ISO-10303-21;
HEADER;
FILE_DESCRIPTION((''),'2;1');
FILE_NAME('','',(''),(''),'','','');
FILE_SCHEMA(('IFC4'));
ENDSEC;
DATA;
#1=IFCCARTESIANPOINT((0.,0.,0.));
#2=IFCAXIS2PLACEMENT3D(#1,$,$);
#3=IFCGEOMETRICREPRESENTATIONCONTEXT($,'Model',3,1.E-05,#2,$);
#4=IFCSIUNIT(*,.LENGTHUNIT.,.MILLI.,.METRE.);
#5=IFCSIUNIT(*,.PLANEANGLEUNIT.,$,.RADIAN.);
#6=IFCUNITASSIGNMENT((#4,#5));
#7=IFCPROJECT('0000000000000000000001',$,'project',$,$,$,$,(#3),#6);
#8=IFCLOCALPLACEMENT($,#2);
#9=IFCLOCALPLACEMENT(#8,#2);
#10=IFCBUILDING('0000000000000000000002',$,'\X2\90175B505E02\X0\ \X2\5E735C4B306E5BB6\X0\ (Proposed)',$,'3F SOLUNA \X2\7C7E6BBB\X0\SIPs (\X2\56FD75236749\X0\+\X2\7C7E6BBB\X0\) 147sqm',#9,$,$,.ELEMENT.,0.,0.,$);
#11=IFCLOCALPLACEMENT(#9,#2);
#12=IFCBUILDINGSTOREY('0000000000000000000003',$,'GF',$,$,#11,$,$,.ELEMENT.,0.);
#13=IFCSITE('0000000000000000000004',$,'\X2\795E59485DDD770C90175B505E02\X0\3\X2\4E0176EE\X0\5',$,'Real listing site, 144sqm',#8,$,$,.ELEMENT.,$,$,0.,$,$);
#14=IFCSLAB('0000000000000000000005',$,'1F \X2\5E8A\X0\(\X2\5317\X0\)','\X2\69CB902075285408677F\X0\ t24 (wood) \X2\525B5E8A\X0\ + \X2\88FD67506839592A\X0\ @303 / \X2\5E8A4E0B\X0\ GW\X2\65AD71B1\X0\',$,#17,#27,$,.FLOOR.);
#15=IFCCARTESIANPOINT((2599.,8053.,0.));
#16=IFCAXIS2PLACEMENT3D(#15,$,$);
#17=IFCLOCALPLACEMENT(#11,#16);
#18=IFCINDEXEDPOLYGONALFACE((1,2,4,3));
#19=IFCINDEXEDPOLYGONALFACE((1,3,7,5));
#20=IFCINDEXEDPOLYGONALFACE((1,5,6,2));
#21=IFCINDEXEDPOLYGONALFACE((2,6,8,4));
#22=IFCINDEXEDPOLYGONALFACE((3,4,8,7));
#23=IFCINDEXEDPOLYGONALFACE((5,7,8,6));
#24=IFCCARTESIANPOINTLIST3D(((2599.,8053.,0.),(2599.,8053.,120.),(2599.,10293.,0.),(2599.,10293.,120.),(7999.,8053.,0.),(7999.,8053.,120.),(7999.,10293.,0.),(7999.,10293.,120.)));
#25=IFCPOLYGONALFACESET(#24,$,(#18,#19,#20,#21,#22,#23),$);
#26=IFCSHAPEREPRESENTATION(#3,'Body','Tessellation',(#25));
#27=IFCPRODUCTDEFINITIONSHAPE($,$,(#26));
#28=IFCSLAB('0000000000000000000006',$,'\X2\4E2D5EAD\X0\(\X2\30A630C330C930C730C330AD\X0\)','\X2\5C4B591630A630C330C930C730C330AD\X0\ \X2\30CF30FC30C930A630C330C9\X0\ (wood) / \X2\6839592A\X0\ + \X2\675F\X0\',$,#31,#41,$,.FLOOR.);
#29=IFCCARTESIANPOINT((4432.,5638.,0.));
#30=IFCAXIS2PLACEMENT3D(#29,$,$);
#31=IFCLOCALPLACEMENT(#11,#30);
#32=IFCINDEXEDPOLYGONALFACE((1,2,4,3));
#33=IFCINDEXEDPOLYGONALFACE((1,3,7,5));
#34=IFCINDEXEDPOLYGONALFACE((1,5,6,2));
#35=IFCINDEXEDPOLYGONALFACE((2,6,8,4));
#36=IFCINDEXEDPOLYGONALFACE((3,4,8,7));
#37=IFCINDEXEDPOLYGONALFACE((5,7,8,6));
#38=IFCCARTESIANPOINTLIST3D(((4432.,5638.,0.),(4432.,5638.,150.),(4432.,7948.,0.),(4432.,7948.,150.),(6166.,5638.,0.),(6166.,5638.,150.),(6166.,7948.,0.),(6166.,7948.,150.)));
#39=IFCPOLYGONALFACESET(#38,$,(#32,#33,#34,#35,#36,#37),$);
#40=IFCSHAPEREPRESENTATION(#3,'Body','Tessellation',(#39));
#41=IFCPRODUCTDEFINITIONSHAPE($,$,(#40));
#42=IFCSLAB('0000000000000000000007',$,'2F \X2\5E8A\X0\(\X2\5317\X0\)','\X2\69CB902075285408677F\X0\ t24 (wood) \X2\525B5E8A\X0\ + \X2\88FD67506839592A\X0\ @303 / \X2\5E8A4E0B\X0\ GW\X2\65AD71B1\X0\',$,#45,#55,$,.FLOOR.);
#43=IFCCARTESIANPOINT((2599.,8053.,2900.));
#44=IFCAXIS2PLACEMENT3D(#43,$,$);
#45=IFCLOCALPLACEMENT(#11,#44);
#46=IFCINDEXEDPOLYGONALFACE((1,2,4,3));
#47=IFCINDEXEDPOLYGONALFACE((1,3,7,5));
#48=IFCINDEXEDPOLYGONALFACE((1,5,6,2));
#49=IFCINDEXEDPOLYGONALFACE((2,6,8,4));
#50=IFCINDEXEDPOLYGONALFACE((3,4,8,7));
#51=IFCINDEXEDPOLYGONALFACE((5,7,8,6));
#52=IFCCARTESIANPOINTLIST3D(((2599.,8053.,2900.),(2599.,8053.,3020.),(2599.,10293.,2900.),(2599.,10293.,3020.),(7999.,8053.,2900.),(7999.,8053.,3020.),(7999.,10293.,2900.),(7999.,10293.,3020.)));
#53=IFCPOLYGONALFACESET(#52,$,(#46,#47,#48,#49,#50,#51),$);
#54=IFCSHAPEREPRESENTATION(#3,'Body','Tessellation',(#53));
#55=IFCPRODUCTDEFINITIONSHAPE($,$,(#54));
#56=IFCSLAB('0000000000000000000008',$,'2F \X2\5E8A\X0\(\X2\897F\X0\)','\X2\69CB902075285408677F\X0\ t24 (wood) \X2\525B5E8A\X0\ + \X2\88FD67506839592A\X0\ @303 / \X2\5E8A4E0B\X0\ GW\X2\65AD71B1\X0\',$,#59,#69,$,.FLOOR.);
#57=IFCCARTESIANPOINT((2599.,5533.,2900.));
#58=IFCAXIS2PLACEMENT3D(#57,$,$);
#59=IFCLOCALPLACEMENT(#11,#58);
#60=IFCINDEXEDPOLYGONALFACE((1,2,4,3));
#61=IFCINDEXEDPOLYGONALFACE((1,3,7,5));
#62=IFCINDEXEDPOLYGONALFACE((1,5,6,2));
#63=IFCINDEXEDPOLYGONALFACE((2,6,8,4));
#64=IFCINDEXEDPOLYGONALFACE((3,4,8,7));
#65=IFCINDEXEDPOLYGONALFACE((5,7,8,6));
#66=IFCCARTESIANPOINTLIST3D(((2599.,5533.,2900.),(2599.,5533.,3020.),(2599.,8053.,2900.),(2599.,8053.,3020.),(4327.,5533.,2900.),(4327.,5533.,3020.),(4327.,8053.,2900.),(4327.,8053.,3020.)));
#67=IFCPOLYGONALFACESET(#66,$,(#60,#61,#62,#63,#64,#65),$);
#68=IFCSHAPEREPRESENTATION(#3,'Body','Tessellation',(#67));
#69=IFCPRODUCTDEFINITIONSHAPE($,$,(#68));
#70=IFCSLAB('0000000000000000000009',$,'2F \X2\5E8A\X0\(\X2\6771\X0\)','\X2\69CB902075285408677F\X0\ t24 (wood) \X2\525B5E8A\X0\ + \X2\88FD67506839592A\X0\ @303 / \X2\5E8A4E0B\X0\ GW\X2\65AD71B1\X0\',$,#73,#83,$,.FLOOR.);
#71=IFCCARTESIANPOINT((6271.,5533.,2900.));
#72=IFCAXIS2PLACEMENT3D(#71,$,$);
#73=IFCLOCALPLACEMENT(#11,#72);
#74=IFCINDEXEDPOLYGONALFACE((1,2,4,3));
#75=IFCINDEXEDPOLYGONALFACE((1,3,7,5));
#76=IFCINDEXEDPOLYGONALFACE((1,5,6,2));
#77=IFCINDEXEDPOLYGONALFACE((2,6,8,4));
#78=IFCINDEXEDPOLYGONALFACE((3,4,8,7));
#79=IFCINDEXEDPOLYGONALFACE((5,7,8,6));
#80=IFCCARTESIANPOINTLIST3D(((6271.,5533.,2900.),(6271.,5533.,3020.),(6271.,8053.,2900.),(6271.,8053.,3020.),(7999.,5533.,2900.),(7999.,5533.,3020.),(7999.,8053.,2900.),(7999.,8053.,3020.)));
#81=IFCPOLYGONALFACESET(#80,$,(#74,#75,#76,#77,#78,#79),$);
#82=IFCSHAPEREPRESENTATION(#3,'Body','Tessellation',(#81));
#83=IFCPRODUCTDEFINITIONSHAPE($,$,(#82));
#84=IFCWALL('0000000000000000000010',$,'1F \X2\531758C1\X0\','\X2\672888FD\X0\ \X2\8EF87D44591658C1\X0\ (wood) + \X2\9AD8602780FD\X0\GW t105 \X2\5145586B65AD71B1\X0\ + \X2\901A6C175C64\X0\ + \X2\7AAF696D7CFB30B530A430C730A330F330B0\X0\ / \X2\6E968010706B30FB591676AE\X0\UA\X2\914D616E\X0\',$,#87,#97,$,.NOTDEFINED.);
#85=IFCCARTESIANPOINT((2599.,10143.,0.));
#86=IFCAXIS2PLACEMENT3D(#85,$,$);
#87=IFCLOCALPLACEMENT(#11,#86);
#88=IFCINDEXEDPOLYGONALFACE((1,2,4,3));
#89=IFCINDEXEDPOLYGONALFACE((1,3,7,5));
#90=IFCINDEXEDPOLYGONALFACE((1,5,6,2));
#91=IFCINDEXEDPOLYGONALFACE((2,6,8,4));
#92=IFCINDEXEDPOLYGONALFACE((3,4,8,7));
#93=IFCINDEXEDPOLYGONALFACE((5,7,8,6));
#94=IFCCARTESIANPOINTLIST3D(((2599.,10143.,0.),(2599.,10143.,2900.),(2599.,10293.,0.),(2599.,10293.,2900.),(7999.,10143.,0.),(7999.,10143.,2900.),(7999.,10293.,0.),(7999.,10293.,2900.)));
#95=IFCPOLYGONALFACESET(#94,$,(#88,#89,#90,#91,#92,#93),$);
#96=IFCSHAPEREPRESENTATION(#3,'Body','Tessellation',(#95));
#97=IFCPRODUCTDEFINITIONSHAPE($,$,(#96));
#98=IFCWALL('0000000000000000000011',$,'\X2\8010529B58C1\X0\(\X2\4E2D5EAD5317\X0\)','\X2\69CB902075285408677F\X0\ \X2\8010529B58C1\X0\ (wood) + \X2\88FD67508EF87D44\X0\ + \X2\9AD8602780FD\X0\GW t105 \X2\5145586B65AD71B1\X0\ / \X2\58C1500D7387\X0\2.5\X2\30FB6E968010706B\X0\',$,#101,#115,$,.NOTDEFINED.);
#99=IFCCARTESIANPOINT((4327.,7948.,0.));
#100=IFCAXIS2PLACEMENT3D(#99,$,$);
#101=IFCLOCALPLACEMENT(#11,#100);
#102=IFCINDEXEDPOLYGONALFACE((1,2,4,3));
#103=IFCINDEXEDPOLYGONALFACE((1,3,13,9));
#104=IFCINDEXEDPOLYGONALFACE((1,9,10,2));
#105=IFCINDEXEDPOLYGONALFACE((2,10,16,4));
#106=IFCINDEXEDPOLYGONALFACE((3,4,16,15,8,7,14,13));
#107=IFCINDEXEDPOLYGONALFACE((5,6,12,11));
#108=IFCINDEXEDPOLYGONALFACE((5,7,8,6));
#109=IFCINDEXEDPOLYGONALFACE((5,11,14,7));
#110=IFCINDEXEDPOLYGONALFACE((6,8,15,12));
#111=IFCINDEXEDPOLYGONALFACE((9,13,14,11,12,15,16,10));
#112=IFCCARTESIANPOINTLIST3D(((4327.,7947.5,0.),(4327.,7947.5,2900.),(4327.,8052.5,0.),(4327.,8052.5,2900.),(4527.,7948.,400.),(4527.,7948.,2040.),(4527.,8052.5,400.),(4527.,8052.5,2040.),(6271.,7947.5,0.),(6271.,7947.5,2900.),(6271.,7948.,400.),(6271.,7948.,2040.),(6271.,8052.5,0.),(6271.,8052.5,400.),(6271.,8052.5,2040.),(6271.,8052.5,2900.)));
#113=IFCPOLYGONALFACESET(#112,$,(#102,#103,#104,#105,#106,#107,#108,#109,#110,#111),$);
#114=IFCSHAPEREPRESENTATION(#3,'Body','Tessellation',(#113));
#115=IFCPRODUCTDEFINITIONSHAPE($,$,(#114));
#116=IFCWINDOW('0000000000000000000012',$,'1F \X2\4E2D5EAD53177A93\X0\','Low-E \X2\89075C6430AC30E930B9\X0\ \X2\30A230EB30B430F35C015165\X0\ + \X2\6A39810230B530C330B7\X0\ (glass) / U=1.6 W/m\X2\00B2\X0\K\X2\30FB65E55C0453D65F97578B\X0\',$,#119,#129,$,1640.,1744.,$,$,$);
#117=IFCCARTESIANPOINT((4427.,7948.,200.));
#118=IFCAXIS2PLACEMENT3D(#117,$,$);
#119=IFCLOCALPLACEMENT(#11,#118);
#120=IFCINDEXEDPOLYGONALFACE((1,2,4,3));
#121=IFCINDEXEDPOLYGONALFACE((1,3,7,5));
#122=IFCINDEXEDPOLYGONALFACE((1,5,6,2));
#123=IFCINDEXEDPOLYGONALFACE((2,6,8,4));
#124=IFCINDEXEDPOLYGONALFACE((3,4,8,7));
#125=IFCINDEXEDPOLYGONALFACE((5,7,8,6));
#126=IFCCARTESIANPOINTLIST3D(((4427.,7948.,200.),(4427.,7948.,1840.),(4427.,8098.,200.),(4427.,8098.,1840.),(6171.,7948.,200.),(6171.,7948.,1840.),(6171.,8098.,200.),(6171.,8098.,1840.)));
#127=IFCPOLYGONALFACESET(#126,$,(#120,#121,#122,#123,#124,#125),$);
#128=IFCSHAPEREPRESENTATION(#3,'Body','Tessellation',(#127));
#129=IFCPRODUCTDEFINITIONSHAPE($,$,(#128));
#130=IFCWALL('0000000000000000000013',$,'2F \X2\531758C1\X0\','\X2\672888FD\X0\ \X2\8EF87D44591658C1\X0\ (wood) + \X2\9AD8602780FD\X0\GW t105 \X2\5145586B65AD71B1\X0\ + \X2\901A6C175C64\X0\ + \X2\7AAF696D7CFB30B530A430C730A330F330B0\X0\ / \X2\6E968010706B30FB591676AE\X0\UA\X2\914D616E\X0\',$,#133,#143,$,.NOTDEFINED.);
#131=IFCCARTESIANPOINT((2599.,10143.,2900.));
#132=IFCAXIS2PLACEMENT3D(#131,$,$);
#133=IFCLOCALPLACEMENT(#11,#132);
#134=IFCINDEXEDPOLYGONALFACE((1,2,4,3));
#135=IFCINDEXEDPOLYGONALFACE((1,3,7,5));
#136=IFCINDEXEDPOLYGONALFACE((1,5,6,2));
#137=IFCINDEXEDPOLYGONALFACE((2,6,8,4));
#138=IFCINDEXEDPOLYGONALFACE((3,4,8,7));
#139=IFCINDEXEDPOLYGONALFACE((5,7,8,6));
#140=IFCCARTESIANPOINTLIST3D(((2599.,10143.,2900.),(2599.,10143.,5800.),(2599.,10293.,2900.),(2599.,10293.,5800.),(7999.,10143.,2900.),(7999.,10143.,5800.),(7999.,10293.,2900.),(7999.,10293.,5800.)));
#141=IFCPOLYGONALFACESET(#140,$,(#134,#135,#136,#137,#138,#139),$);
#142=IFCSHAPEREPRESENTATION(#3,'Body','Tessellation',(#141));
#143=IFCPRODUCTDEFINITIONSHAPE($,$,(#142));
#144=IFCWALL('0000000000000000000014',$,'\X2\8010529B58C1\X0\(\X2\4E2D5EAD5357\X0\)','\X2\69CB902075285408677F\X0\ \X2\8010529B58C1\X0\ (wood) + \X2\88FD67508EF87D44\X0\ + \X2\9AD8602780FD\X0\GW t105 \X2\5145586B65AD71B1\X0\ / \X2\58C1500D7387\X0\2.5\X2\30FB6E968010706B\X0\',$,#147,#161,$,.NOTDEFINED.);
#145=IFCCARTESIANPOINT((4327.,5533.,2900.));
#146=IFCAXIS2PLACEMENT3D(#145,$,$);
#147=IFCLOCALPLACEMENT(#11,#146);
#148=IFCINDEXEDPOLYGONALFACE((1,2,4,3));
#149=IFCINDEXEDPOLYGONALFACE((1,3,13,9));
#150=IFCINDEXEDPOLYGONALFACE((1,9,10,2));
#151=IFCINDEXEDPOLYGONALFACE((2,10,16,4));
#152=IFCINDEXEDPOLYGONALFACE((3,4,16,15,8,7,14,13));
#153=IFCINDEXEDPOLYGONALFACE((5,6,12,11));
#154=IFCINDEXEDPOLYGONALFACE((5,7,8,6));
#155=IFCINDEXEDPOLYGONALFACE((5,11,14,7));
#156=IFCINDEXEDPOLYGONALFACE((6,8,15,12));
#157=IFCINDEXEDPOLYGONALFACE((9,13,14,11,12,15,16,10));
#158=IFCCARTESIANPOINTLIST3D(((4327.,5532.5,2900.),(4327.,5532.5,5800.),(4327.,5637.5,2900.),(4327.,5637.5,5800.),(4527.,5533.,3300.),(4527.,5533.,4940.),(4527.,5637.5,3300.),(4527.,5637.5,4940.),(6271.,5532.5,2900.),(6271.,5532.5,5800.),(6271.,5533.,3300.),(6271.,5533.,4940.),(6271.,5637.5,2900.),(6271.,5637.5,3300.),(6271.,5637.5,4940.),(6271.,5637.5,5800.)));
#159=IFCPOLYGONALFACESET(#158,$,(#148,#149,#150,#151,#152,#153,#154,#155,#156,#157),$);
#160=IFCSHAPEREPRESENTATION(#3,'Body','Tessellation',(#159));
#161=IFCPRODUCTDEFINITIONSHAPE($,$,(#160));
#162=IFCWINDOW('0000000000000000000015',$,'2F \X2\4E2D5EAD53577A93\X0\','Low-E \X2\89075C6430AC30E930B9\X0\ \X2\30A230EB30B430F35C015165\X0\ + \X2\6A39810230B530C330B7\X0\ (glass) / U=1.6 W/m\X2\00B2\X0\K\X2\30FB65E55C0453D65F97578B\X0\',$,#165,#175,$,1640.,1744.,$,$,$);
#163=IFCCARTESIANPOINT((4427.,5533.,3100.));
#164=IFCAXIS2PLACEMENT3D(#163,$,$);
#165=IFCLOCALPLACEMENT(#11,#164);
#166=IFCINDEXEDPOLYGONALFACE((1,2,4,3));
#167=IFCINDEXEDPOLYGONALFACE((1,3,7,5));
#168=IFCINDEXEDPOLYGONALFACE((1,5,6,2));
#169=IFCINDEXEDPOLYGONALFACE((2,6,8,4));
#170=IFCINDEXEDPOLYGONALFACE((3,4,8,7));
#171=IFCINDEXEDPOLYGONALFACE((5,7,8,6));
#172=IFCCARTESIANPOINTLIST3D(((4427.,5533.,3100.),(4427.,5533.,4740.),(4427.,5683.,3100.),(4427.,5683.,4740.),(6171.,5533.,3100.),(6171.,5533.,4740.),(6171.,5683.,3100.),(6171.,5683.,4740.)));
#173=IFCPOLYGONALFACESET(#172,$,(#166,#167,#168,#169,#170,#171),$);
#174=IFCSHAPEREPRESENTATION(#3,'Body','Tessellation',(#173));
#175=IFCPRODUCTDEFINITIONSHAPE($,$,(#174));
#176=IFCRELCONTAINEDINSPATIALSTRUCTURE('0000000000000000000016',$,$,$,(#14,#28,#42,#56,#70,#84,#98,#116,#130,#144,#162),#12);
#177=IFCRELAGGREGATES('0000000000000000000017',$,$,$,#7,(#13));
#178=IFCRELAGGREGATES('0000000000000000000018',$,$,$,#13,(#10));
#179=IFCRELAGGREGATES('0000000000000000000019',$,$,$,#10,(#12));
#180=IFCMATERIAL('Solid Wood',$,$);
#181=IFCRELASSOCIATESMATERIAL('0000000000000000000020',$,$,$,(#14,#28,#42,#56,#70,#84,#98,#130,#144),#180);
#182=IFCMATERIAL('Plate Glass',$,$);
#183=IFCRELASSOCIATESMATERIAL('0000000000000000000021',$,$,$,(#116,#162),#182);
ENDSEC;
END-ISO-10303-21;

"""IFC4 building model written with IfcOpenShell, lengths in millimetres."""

from ifc_helpers import new_model, si_unit, frame, frame_2d, origin, place, context, project, spatial, rectangle, extrude, material, element, fill, save


model = new_model("IFC4")

# Units and contexts
model_context = context("Model", 3, precision=1e-05, world=origin())
ifc_project = project(units=[si_unit("LENGTHUNIT", "METRE", prefix="MILLI"), si_unit("PLANEANGLEUNIT", "RADIAN")], contexts=[model_context])

# Site, building, storey
site_placement = place(None, origin())
site = spatial("IfcSite", under=ifc_project, at=site_placement, Name="神奈川県逗子市3丁目5", ObjectType="Real listing site, 144sqm", CompositionType="ELEMENT", RefElevation=0.0)
building_placement = place(site_placement, origin())
building = spatial("IfcBuilding", under=site, at=building_placement, Name="逗子市 平屋の家 (Proposed)", ObjectType="3F SOLUNA 籾殻SIPs (国産杉+籾殻) 147sqm", CompositionType="ELEMENT", ElevationOfRefHeight=0.0, ElevationOfTerrain=0.0)
storey_placement = place(building_placement, origin())
storey = spatial("IfcBuildingStorey", under=building, at=storey_placement, Name="GF", CompositionType="ELEMENT", Elevation=0.0)

# Slabs
ifc_material_1 = material(Name="Solid Wood")
slab_1_placement = place(storey_placement, frame((2599.0, 8053.0, 0.0)))
element("IfcSlab", 1, at=slab_1_placement, inside=storey, material=ifc_material_1, Name="1F 床(北)", Description="構造用合板 t24 (wood) 剛床 + 製材根太 @303 / 床下 GW断熱", PredefinedType="FLOOR", context=model_context, shape_type="SweptSolid", body=[
    extrude(rectangle(XDim=5400.0, YDim=2240.0, at=frame_2d((2700.0, 1120.0))), frame((2599.0, 8053.0, 0.0)), (0.0, 0.0, 1.0), 120.0),
])
slab_2_placement = place(storey_placement, frame((4432.0, 5638.0, 0.0)))
element("IfcSlab", 2, at=slab_2_placement, inside=storey, material=ifc_material_1, Name="中庭(ウッドデッキ)", Description="屋外ウッドデッキ ハードウッド (wood) / 根太 + 束", PredefinedType="FLOOR", context=model_context, shape_type="SweptSolid", body=[
    extrude(rectangle(XDim=1734.0, YDim=2310.0, at=frame_2d((867.0, 1155.0))), frame((4432.0, 5638.0, 0.0)), (0.0, 0.0, 1.0), 150.0),
])
slab_3_placement = place(storey_placement, frame((2599.0, 8053.0, 2900.0)))
element("IfcSlab", 3, at=slab_3_placement, inside=storey, material=ifc_material_1, Name="2F 床(北)", Description="構造用合板 t24 (wood) 剛床 + 製材根太 @303 / 床下 GW断熱", PredefinedType="FLOOR", context=model_context, shape_type="SweptSolid", body=[
    extrude(rectangle(XDim=5400.0, YDim=2240.0, at=frame_2d((2700.0, 1120.0))), frame((2599.0, 8053.0, 2900.0)), (0.0, 0.0, 1.0), 120.0),
])
slab_4_placement = place(storey_placement, frame((2599.0, 5533.0, 2900.0)))
element("IfcSlab", 4, at=slab_4_placement, inside=storey, material=ifc_material_1, Name="2F 床(西)", Description="構造用合板 t24 (wood) 剛床 + 製材根太 @303 / 床下 GW断熱", PredefinedType="FLOOR", context=model_context, shape_type="SweptSolid", body=[
    extrude(rectangle(XDim=1728.0, YDim=2520.0, at=frame_2d((864.0, 1260.0))), frame((2599.0, 5533.0, 2900.0)), (0.0, 0.0, 1.0), 120.0),
])
slab_5_placement = place(storey_placement, frame((6271.0, 5533.0, 2900.0)))
element("IfcSlab", 5, at=slab_5_placement, inside=storey, material=ifc_material_1, Name="2F 床(東)", Description="構造用合板 t24 (wood) 剛床 + 製材根太 @303 / 床下 GW断熱", PredefinedType="FLOOR", context=model_context, shape_type="SweptSolid", body=[
    extrude(rectangle(XDim=1728.0, YDim=2520.0, at=frame_2d((864.0, 1260.0))), frame((6271.0, 5533.0, 2900.0)), (0.0, 0.0, 1.0), 120.0),
])

# Wall
wall_1_placement = place(storey_placement, frame((2599.0, 10143.0, 0.0)))
element("IfcWall", 6, at=wall_1_placement, inside=storey, material=ifc_material_1, Name="1F 北壁", Description="木製 軸組外壁 (wood) + 高性能GW t105 充填断熱 + 通気層 + 窯業系サイディング / 準耐火・外皮UA配慮", PredefinedType="NOTDEFINED", context=model_context, shape_type="SweptSolid", body=[
    extrude(rectangle(XDim=5400.0, YDim=150.0, at=frame_2d((2700.0, 75.0))), frame((2599.0, 10143.0, 0.0)), (0.0, 0.0, 1.0), 2900.0),
])

# Wall, opening, window
wall_2_placement = place(storey_placement, frame((4327.0, 7948.0, 0.0)))
wall_2 = element("IfcWall", 7, at=wall_2_placement, inside=storey, material=ifc_material_1, Name="耐力壁(中庭北)", Description="構造用合板 耐力壁 (wood) + 製材軸組 + 高性能GW t105 充填断熱 / 壁倍率2.5・準耐火", PredefinedType="NOTDEFINED", context=model_context, shape_type="SweptSolid", body=[
    extrude(rectangle(XDim=1944.0, YDim=105.0, at=frame_2d((972.0, 52.0))), frame((4327.0, 7948.0, 0.0)), (0.0, 0.0, 1.0), 2900.0),
])
opening_1_placement = place(storey_placement, frame((4427.0, 7948.0, 200.0)))
opening_1 = element("IfcOpeningElement", 8, at=opening_1_placement, cuts=wall_2, PredefinedType="NOTDEFINED", context=model_context, shape_type="SweptSolid", body=[
    extrude(rectangle(XDim=1744.0, YDim=150.0, at=frame_2d((872.0, 75.0))), frame((4427.0, 7948.0, 200.0)), (0.0, 0.0, 1.0), 1640.0),
])
ifc_material_2 = material(Name="Plate Glass")
window_1_placement = place(storey_placement, frame((4427.0, 7948.0, 200.0)))
window_1 = element("IfcWindow", 9, at=window_1_placement, inside=storey, material=ifc_material_2, Name="1F 中庭北窓", Description="Low-E 複層ガラス アルゴン封入 + 樹脂サッシ (glass) / U=1.6 W/m²K・日射取得型", OverallHeight=1640.0, OverallWidth=1744.0, context=model_context, shape_type="SweptSolid", body=[
    extrude(rectangle(XDim=1744.0, YDim=150.0, at=frame_2d((872.0, 75.0))), frame((4427.0, 7948.0, 200.0)), (0.0, 0.0, 1.0), 1640.0),
])
fill(opening_1, window_1)

# Wall
wall_3_placement = place(storey_placement, frame((2599.0, 10143.0, 2900.0)))
element("IfcWall", 10, at=wall_3_placement, inside=storey, material=ifc_material_1, Name="2F 北壁", Description="木製 軸組外壁 (wood) + 高性能GW t105 充填断熱 + 通気層 + 窯業系サイディング / 準耐火・外皮UA配慮", PredefinedType="NOTDEFINED", context=model_context, shape_type="SweptSolid", body=[
    extrude(rectangle(XDim=5400.0, YDim=150.0, at=frame_2d((2700.0, 75.0))), frame((2599.0, 10143.0, 2900.0)), (0.0, 0.0, 1.0), 2900.0),
])

# Wall, opening, window
wall_4_placement = place(storey_placement, frame((4327.0, 5533.0, 2900.0)))
wall_4 = element("IfcWall", 11, at=wall_4_placement, inside=storey, material=ifc_material_1, Name="耐力壁(中庭南)", Description="構造用合板 耐力壁 (wood) + 製材軸組 + 高性能GW t105 充填断熱 / 壁倍率2.5・準耐火", PredefinedType="NOTDEFINED", context=model_context, shape_type="SweptSolid", body=[
    extrude(rectangle(XDim=1944.0, YDim=105.0, at=frame_2d((972.0, 52.0))), frame((4327.0, 5533.0, 2900.0)), (0.0, 0.0, 1.0), 2900.0),
])
opening_2_placement = place(storey_placement, frame((4427.0, 5533.0, 3100.0)))
opening_2 = element("IfcOpeningElement", 12, at=opening_2_placement, cuts=wall_4, PredefinedType="NOTDEFINED", context=model_context, shape_type="SweptSolid", body=[
    extrude(rectangle(XDim=1744.0, YDim=150.0, at=frame_2d((872.0, 75.0))), frame((4427.0, 5533.0, 3100.0)), (0.0, 0.0, 1.0), 1640.0),
])
window_2_placement = place(storey_placement, frame((4427.0, 5533.0, 3100.0)))
window_2 = element("IfcWindow", 13, at=window_2_placement, inside=storey, material=ifc_material_2, Name="2F 中庭南窓", Description="Low-E 複層ガラス アルゴン封入 + 樹脂サッシ (glass) / U=1.6 W/m²K・日射取得型", OverallHeight=1640.0, OverallWidth=1744.0, context=model_context, shape_type="SweptSolid", body=[
    extrude(rectangle(XDim=1744.0, YDim=150.0, at=frame_2d((872.0, 75.0))), frame((4427.0, 5533.0, 3100.0)), (0.0, 0.0, 1.0), 1640.0),
])
fill(opening_2, window_2)

save(model, "model.ifc")
